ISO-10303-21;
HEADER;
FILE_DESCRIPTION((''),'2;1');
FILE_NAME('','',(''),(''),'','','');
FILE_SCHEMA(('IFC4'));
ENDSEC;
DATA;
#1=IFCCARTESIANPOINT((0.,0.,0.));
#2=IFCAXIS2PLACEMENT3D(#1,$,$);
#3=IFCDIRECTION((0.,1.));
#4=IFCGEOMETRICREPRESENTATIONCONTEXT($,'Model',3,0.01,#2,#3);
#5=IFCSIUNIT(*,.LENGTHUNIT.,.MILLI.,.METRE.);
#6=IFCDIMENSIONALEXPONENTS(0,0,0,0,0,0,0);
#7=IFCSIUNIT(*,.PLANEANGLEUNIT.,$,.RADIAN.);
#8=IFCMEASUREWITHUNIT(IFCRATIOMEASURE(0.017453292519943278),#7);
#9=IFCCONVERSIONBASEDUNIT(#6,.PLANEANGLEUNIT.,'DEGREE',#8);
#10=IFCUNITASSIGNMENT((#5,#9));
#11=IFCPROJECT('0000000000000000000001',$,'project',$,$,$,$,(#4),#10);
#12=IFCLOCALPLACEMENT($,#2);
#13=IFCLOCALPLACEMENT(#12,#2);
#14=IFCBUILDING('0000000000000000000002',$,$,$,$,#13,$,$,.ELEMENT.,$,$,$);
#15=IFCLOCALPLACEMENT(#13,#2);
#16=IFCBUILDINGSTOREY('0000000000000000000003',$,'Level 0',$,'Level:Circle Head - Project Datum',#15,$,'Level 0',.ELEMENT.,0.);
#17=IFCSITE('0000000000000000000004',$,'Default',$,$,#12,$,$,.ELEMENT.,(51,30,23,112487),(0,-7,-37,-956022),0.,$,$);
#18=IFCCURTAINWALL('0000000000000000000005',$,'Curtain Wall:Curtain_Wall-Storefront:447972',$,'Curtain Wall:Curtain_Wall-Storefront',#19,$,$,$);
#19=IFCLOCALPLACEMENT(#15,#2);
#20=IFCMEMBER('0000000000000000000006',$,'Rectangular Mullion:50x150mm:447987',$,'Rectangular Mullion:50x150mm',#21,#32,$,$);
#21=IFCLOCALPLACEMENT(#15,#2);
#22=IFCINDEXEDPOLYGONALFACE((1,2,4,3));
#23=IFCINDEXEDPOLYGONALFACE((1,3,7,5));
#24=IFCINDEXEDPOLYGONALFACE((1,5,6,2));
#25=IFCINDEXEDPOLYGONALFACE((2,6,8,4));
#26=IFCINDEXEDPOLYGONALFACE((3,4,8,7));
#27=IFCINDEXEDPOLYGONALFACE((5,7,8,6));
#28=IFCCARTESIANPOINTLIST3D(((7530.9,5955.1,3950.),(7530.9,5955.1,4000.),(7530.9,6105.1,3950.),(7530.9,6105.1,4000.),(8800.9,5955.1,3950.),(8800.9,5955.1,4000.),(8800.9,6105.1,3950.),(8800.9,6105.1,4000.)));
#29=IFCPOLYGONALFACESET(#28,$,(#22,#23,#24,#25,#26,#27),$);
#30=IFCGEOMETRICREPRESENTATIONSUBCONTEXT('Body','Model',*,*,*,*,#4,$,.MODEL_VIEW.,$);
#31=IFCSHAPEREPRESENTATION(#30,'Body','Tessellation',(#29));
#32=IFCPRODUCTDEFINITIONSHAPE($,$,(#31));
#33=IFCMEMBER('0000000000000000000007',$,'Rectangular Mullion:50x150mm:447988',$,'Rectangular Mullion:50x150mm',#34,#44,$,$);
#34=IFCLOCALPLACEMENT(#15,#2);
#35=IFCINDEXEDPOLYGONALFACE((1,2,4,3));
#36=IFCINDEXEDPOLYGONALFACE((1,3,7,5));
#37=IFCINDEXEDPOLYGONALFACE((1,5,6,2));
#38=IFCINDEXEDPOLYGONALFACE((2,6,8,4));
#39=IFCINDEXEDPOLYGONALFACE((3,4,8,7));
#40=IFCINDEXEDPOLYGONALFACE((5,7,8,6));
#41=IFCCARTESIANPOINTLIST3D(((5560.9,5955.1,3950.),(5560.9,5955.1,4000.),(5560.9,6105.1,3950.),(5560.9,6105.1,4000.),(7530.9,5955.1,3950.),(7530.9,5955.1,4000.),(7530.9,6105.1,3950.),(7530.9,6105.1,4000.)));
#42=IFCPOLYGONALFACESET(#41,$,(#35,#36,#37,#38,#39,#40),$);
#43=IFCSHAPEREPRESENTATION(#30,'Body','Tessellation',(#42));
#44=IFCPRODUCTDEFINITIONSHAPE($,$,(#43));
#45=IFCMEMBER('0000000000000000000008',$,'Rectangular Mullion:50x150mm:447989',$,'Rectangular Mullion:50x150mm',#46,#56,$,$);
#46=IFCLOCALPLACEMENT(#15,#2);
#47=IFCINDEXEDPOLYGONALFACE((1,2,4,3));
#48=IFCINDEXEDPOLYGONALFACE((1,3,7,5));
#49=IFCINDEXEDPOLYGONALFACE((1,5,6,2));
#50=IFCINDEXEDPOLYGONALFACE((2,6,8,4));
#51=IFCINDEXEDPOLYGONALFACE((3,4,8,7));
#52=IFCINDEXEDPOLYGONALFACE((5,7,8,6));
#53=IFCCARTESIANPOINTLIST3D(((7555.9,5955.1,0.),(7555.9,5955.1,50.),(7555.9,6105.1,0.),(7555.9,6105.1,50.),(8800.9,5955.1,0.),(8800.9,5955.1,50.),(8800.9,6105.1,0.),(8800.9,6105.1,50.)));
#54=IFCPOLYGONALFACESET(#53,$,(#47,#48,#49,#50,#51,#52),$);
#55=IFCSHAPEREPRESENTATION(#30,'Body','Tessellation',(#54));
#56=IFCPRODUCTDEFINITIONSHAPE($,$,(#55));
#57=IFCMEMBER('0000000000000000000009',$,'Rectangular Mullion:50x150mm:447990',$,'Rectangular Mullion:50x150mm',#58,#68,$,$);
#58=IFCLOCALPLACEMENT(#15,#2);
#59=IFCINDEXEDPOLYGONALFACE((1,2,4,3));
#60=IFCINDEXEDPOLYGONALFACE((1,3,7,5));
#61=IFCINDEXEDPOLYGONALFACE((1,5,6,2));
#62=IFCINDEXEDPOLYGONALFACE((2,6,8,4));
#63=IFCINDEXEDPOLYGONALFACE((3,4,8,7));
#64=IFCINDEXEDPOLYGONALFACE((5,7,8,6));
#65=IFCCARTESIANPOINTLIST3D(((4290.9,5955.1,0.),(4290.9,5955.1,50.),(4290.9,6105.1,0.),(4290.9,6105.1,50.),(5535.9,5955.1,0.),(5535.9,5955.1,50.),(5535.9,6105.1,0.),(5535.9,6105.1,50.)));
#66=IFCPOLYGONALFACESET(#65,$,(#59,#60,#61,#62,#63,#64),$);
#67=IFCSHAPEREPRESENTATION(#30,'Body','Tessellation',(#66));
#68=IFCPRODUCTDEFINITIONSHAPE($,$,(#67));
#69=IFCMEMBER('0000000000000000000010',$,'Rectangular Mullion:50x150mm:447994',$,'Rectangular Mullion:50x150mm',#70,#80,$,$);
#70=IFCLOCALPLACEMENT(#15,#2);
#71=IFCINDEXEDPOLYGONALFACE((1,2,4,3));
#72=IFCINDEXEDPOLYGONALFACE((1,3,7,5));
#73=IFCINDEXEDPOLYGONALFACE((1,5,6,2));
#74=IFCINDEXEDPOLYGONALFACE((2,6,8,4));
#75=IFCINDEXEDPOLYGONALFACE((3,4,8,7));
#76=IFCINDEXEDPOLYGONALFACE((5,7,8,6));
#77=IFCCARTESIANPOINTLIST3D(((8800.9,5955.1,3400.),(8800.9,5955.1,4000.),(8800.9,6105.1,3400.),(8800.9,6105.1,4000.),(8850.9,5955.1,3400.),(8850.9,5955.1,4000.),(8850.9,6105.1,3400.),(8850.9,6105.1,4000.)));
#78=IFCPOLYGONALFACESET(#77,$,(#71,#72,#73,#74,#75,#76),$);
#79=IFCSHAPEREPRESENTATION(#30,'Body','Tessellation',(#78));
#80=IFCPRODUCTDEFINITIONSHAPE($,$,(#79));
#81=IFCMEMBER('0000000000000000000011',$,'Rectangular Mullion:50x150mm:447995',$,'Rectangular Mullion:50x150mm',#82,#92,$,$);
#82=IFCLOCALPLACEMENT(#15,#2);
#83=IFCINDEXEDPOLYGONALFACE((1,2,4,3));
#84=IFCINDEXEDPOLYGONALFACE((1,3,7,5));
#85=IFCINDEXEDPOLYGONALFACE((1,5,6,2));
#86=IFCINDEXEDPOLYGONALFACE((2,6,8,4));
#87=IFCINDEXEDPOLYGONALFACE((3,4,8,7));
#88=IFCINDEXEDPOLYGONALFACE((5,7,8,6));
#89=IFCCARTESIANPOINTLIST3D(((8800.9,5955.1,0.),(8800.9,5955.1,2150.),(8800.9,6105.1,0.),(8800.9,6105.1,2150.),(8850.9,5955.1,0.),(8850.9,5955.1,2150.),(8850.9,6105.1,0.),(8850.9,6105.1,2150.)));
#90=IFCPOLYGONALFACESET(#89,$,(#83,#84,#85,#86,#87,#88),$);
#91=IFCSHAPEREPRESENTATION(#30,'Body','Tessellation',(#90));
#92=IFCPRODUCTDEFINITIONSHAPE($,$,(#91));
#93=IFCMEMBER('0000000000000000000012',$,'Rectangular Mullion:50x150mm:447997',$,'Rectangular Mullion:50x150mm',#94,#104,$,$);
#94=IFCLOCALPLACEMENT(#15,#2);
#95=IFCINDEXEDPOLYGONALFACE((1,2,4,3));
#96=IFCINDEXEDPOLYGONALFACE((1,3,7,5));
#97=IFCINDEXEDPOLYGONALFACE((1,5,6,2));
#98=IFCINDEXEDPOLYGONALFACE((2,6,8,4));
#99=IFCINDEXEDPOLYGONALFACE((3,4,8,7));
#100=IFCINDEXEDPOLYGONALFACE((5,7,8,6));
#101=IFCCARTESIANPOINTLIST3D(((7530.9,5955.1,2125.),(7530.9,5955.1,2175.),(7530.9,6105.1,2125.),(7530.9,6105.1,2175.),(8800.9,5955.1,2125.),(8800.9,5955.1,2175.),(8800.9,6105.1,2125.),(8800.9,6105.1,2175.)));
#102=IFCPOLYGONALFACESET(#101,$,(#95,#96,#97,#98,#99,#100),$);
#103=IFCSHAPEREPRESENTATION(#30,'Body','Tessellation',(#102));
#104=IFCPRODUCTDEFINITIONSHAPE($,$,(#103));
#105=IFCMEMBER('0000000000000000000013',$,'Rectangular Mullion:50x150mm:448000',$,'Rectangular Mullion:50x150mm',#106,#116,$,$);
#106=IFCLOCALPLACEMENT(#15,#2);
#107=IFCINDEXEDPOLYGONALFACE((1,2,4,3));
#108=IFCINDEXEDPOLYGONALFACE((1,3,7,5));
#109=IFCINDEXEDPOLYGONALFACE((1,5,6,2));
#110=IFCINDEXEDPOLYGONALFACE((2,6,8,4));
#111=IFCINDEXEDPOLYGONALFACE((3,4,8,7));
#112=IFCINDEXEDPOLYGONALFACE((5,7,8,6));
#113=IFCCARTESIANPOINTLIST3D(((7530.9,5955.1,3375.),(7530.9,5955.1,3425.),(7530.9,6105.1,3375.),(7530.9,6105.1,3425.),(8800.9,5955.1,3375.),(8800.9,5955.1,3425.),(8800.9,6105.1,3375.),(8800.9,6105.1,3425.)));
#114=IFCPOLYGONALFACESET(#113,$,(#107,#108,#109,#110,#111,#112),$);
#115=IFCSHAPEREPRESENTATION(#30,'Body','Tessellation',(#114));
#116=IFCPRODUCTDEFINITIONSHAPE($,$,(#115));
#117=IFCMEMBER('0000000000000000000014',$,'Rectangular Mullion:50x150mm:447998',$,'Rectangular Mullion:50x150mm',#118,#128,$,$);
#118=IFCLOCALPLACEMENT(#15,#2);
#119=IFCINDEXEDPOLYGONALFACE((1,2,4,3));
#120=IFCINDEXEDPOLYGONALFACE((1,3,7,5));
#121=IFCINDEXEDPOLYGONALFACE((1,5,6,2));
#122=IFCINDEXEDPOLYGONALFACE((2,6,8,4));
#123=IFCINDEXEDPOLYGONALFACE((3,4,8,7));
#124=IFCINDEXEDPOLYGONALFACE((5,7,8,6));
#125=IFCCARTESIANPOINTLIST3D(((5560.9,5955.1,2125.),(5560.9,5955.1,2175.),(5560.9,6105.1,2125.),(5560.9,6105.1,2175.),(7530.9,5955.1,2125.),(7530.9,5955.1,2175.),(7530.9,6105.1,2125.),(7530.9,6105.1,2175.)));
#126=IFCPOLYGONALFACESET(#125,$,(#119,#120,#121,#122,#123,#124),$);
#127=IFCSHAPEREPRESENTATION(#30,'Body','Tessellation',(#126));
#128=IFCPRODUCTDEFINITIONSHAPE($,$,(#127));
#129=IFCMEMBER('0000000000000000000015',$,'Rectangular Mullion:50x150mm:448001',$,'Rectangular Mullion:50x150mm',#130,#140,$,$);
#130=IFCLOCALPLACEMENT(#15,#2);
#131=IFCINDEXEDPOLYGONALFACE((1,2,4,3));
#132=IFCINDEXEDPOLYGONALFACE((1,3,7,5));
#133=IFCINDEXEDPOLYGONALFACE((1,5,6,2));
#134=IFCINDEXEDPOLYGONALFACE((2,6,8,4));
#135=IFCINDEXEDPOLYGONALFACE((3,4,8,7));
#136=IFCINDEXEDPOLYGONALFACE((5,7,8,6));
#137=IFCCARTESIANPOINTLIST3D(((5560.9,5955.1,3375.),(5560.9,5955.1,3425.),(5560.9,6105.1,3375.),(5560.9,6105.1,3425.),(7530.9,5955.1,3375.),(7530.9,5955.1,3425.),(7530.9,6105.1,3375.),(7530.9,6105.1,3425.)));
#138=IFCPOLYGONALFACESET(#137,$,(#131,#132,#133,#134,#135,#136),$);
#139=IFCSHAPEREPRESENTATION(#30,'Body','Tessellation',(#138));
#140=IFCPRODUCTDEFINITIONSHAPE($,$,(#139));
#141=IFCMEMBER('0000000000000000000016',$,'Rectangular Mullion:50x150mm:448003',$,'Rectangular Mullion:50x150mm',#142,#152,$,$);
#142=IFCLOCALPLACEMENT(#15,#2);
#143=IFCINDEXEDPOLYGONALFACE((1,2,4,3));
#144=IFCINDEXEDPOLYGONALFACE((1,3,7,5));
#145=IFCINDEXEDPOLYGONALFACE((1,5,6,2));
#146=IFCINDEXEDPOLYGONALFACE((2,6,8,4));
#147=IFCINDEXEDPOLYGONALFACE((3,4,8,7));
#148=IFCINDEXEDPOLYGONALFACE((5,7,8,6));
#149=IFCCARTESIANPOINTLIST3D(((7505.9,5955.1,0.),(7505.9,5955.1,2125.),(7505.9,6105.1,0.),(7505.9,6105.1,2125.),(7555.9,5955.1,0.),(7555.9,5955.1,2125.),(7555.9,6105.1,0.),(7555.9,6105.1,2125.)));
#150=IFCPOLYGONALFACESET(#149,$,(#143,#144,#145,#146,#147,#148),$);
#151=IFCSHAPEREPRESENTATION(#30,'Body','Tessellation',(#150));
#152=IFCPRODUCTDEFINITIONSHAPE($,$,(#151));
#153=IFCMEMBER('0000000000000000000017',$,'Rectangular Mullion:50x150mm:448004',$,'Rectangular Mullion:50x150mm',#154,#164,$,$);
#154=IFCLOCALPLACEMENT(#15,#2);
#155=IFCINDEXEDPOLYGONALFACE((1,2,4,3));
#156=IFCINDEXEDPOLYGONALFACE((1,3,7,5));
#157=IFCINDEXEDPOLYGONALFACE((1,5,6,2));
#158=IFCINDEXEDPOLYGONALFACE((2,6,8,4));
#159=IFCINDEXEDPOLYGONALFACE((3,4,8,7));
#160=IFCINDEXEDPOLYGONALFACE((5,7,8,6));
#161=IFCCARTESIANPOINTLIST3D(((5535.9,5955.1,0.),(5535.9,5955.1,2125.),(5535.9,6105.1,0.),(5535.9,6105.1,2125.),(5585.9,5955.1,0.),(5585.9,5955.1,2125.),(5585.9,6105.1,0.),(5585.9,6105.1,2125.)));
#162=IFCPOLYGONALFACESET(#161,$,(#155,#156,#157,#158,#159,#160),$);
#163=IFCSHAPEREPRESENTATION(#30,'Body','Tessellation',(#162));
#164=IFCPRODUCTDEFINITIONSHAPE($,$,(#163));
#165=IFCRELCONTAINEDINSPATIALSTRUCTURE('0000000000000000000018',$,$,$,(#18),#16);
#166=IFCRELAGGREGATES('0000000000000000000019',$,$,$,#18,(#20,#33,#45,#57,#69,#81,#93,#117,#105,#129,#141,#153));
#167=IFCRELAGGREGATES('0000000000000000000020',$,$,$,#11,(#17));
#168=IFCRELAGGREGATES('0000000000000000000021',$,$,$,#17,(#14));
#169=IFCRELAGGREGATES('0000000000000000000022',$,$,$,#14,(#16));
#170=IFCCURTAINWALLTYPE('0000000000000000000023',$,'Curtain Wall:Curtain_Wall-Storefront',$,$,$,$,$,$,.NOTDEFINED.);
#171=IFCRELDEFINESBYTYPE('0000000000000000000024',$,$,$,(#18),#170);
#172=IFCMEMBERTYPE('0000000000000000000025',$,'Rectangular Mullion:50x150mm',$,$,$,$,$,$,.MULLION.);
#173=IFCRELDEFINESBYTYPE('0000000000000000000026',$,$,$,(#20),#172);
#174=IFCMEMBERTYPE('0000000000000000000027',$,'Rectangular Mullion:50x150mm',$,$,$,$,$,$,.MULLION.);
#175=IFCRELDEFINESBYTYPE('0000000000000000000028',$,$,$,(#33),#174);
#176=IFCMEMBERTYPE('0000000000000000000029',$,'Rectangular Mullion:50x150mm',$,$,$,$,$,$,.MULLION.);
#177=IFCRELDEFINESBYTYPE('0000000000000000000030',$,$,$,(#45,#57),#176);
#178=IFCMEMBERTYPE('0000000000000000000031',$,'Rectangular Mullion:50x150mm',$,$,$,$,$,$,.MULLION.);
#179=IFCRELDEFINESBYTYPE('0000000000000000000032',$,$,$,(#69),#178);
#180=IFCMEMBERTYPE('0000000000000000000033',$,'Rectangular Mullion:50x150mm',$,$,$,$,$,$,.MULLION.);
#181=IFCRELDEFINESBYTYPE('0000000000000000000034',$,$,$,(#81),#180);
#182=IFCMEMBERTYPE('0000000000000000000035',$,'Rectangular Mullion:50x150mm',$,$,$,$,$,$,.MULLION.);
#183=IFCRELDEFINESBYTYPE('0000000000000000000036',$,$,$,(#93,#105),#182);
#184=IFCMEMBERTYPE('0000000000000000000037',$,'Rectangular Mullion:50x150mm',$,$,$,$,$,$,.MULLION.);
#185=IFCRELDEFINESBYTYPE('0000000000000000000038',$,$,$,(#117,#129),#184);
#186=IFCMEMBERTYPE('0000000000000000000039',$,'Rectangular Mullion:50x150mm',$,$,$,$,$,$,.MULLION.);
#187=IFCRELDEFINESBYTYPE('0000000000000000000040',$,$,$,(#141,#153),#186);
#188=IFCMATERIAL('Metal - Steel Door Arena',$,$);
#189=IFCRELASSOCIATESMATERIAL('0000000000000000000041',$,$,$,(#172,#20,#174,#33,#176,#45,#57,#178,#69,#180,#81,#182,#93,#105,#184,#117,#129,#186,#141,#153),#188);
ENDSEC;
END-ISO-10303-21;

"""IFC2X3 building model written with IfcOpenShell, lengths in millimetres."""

from ifc_helpers import new_model, entity, si_unit, converted_unit, direction, frame, origin, origin_2d_with_axis, place, context, subcontext, project, spatial, rectangle, extrude, source, transform, mapped, material, type_object, type_shapes, element, aggregate, save


model = new_model("IFC2X3")

# Units and contexts
model_context = context("Model", 3, precision=0.01, world=origin(), true_north=direction((0.0, 1.0)))
body_context = subcontext(model_context, "Body", "Model", "MODEL_VIEW")
ifc_project = project(units=[si_unit("LENGTHUNIT", "METRE", prefix="MILLI"), converted_unit("PLANEANGLEUNIT", "DEGREE", entity("IfcRatioMeasure", 0.017453292519943278), si_unit("PLANEANGLEUNIT", "RADIAN"), dimensions=[0, 0, 0, 0, 0, 0, 0])], contexts=[model_context])

# Site, building, storey
site_placement = place(None, origin())
site = spatial("IfcSite", under=ifc_project, at=site_placement, Name="Default", CompositionType="ELEMENT", RefLatitude=(51, 30, 23, 112487), RefLongitude=(0, -7, -37, -956022), RefElevation=0.0)
building_placement = place(site_placement, origin())
building = spatial("IfcBuilding", under=site, at=building_placement, CompositionType="ELEMENT")
storey_placement = place(building_placement, origin())
storey = spatial("IfcBuildingStorey", under=building, at=storey_placement, Name="Level 0", ObjectType="Level:Circle Head - Project Datum", LongName="Level 0", CompositionType="ELEMENT", Elevation=0.0)

# Curtain wall, members
curtain_wall_type = type_object("IfcCurtainWallType", Name="Curtain Wall:Curtain_Wall-Storefront", PredefinedType="NOTDEFINED")
curtain_wall_placement = place(storey_placement, origin())
curtain_wall = element("IfcCurtainWall", 1, at=curtain_wall_placement, inside=storey, type_object=curtain_wall_type, Name="Curtain Wall:Curtain_Wall-Storefront:447972", ObjectType="Curtain Wall:Curtain_Wall-Storefront")
ifc_material_1 = material(Name="Metal - Steel Door Arena")
member_type_1 = type_object("IfcMemberType", Name="Rectangular Mullion:50x150mm", PredefinedType="MULLION", material=ifc_material_1)
shared_shape_1 = source(origin(), body_context, "Body", "SweptSolid", [
    extrude(rectangle(XDim=150.0, YDim=50.0, at=origin_2d_with_axis()), frame((-25.0, 0.0, -1270.0), z_axis=(0.0, 0.0, 1.0), x_axis=(0.0, -1.0, 0.0)), (0.0, 0.0, 1.0), 1270.0),
])
type_shapes(member_type_1, [shared_shape_1])
member_1_placement = place(curtain_wall_placement, frame((7530.9, 6030.1, 4000.0), z_axis=(-1.0, 0.0, 0.0), x_axis=(0.0, 0.0, 1.0)))
member_1 = element("IfcMember", 2, at=member_1_placement, type_object=member_type_1, material=ifc_material_1, Name="Rectangular Mullion:50x150mm:447987", ObjectType="Rectangular Mullion:50x150mm", context=body_context, shape_type="MappedRepresentation", body=[
    mapped(shared_shape_1, transform((0.0, 0.0, 0.0), scale=1.0)),
])
member_type_2 = type_object("IfcMemberType", Name="Rectangular Mullion:50x150mm", PredefinedType="MULLION", material=ifc_material_1)
shared_shape_2 = source(origin(), body_context, "Body", "SweptSolid", [
    extrude(rectangle(XDim=150.0, YDim=50.0, at=origin_2d_with_axis()), frame((-25.0, 0.0, -1970.0), z_axis=(0.0, 0.0, 1.0), x_axis=(0.0, -1.0, 0.0)), (0.0, 0.0, 1.0), 1970.0),
])
type_shapes(member_type_2, [shared_shape_2])
member_2_placement = place(curtain_wall_placement, frame((5560.9, 6030.1, 4000.0), z_axis=(-1.0, 0.0, 0.0), x_axis=(0.0, 0.0, 1.0)))
member_2 = element("IfcMember", 3, at=member_2_placement, type_object=member_type_2, material=ifc_material_1, Name="Rectangular Mullion:50x150mm:447988", ObjectType="Rectangular Mullion:50x150mm", context=body_context, shape_type="MappedRepresentation", body=[
    mapped(shared_shape_2, transform((0.0, 0.0, 0.0), scale=1.0)),
])
member_type_3 = type_object("IfcMemberType", Name="Rectangular Mullion:50x150mm", PredefinedType="MULLION", material=ifc_material_1)
shared_shape_3 = source(origin(), body_context, "Body", "SweptSolid", [
    extrude(rectangle(XDim=150.0, YDim=50.0, at=origin_2d_with_axis()), frame((-25.0, 0.0, -1245.0), z_axis=(0.0, 0.0, 1.0), x_axis=(0.0, -1.0, 0.0)), (0.0, 0.0, 1.0), 1245.0),
])
type_shapes(member_type_3, [shared_shape_3])
member_3_placement = place(curtain_wall_placement, frame((8800.9, 6030.1, 0.0), z_axis=(1.0, 0.0, 0.0), x_axis=(0.0, 0.0, -1.0)))
member_3 = element("IfcMember", 4, at=member_3_placement, type_object=member_type_3, material=ifc_material_1, Name="Rectangular Mullion:50x150mm:447989", ObjectType="Rectangular Mullion:50x150mm", context=body_context, shape_type="MappedRepresentation", body=[
    mapped(shared_shape_3, transform((0.0, 0.0, 0.0), scale=1.0)),
])
member_4_placement = place(curtain_wall_placement, frame((5535.9, 6030.1, 0.0), z_axis=(1.0, 0.0, 0.0), x_axis=(0.0, 0.0, -1.0)))
member_4 = element("IfcMember", 5, at=member_4_placement, type_object=member_type_3, material=ifc_material_1, Name="Rectangular Mullion:50x150mm:447990", ObjectType="Rectangular Mullion:50x150mm", context=body_context, shape_type="MappedRepresentation", body=[
    mapped(shared_shape_3, transform((0.0, 0.0, 0.0), scale=1.0)),
])
member_type_4 = type_object("IfcMemberType", Name="Rectangular Mullion:50x150mm", PredefinedType="MULLION", material=ifc_material_1)
shared_shape_4 = source(origin(), body_context, "Body", "SweptSolid", [
    extrude(rectangle(XDim=150.0, YDim=50.0, at=origin_2d_with_axis()), frame((-25.0, 0.0, -600.0), z_axis=(0.0, 0.0, 1.0), x_axis=(0.0, -1.0, 0.0)), (0.0, 0.0, 1.0), 600.0),
])
type_shapes(member_type_4, [shared_shape_4])
member_5_placement = place(curtain_wall_placement, frame((8850.9, 6030.1, 4000.0)))
member_5 = element("IfcMember", 6, at=member_5_placement, type_object=member_type_4, material=ifc_material_1, Name="Rectangular Mullion:50x150mm:447994", ObjectType="Rectangular Mullion:50x150mm", context=body_context, shape_type="MappedRepresentation", body=[
    mapped(shared_shape_4, transform((0.0, 0.0, 0.0), scale=1.0)),
])
member_type_5 = type_object("IfcMemberType", Name="Rectangular Mullion:50x150mm", PredefinedType="MULLION", material=ifc_material_1)
shared_shape_5 = source(origin(), body_context, "Body", "SweptSolid", [
    extrude(rectangle(XDim=150.0, YDim=50.0, at=origin_2d_with_axis()), frame((-25.0, 0.0, -2150.0), z_axis=(0.0, 0.0, 1.0), x_axis=(0.0, -1.0, 0.0)), (0.0, 0.0, 1.0), 2150.0),
])
type_shapes(member_type_5, [shared_shape_5])
member_6_placement = place(curtain_wall_placement, frame((8850.9, 6030.1, 2150.0)))
member_6 = element("IfcMember", 7, at=member_6_placement, type_object=member_type_5, material=ifc_material_1, Name="Rectangular Mullion:50x150mm:447995", ObjectType="Rectangular Mullion:50x150mm", context=body_context, shape_type="MappedRepresentation", body=[
    mapped(shared_shape_5, transform((0.0, 0.0, 0.0), scale=1.0)),
])
member_type_6 = type_object("IfcMemberType", Name="Rectangular Mullion:50x150mm", PredefinedType="MULLION", material=ifc_material_1)
shared_shape_6 = source(origin(), body_context, "Body", "SweptSolid", [
    extrude(rectangle(XDim=150.0, YDim=50.0, at=origin_2d_with_axis()), frame((0.0, 0.0, -1270.0), z_axis=(0.0, 0.0, 1.0), x_axis=(0.0, -1.0, 0.0)), (0.0, 0.0, 1.0), 1270.0),
])
type_shapes(member_type_6, [shared_shape_6])
member_7_placement = place(curtain_wall_placement, frame((7530.9, 6030.1, 2150.0), z_axis=(-1.0, 0.0, 0.0), x_axis=(0.0, 0.0, 1.0)))
member_7 = element("IfcMember", 8, at=member_7_placement, type_object=member_type_6, material=ifc_material_1, Name="Rectangular Mullion:50x150mm:447997", ObjectType="Rectangular Mullion:50x150mm", context=body_context, shape_type="MappedRepresentation", body=[
    mapped(shared_shape_6, transform((0.0, 0.0, 0.0), scale=1.0)),
])
member_8_placement = place(curtain_wall_placement, frame((7530.9, 6030.1, 3400.0), z_axis=(-1.0, 0.0, 0.0), x_axis=(0.0, 0.0, 1.0)))
member_8 = element("IfcMember", 9, at=member_8_placement, type_object=member_type_6, material=ifc_material_1, Name="Rectangular Mullion:50x150mm:448000", ObjectType="Rectangular Mullion:50x150mm", context=body_context, shape_type="MappedRepresentation", body=[
    mapped(shared_shape_6, transform((0.0, 0.0, 0.0), scale=1.0)),
])
member_type_7 = type_object("IfcMemberType", Name="Rectangular Mullion:50x150mm", PredefinedType="MULLION", material=ifc_material_1)
shared_shape_7 = source(origin(), body_context, "Body", "SweptSolid", [
    extrude(rectangle(XDim=150.0, YDim=50.0, at=origin_2d_with_axis()), frame((0.0, 0.0, -1970.0), z_axis=(0.0, 0.0, 1.0), x_axis=(0.0, -1.0, 0.0)), (0.0, 0.0, 1.0), 1970.0),
])
type_shapes(member_type_7, [shared_shape_7])
member_9_placement = place(curtain_wall_placement, frame((5560.9, 6030.1, 2150.0), z_axis=(-1.0, 0.0, 0.0), x_axis=(0.0, 0.0, 1.0)))
member_9 = element("IfcMember", 10, at=member_9_placement, type_object=member_type_7, material=ifc_material_1, Name="Rectangular Mullion:50x150mm:447998", ObjectType="Rectangular Mullion:50x150mm", context=body_context, shape_type="MappedRepresentation", body=[
    mapped(shared_shape_7, transform((0.0, 0.0, 0.0), scale=1.0)),
])
member_10_placement = place(curtain_wall_placement, frame((5560.9, 6030.1, 3400.0), z_axis=(-1.0, 0.0, 0.0), x_axis=(0.0, 0.0, 1.0)))
member_10 = element("IfcMember", 11, at=member_10_placement, type_object=member_type_7, material=ifc_material_1, Name="Rectangular Mullion:50x150mm:448001", ObjectType="Rectangular Mullion:50x150mm", context=body_context, shape_type="MappedRepresentation", body=[
    mapped(shared_shape_7, transform((0.0, 0.0, 0.0), scale=1.0)),
])
member_type_8 = type_object("IfcMemberType", Name="Rectangular Mullion:50x150mm", PredefinedType="MULLION", material=ifc_material_1)
shared_shape_8 = source(origin(), body_context, "Body", "SweptSolid", [
    extrude(rectangle(XDim=150.0, YDim=50.0, at=origin_2d_with_axis()), frame((0.0, 0.0, -2125.0), z_axis=(0.0, 0.0, 1.0), x_axis=(0.0, -1.0, 0.0)), (0.0, 0.0, 1.0), 2125.0),
])
type_shapes(member_type_8, [shared_shape_8])
member_11_placement = place(curtain_wall_placement, frame((7530.9, 6030.1, 0.0), z_axis=(0.0, 0.0, -1.0), x_axis=(-1.0, 0.0, 0.0)))
member_11 = element("IfcMember", 12, at=member_11_placement, type_object=member_type_8, material=ifc_material_1, Name="Rectangular Mullion:50x150mm:448003", ObjectType="Rectangular Mullion:50x150mm", context=body_context, shape_type="MappedRepresentation", body=[
    mapped(shared_shape_8, transform((0.0, 0.0, 0.0), scale=1.0)),
])
member_12_placement = place(curtain_wall_placement, frame((5560.9, 6030.1, 0.0), z_axis=(0.0, 0.0, -1.0), x_axis=(-1.0, 0.0, 0.0)))
member_12 = element("IfcMember", 13, at=member_12_placement, type_object=member_type_8, material=ifc_material_1, Name="Rectangular Mullion:50x150mm:448004", ObjectType="Rectangular Mullion:50x150mm", context=body_context, shape_type="MappedRepresentation", body=[
    mapped(shared_shape_8, transform((0.0, 0.0, 0.0), scale=1.0)),
])
aggregate(curtain_wall, [member_1, member_2, member_3, member_4, member_5, member_6, member_7, member_9, member_8, member_10, member_11, member_12])

save(model, "model.ifc")
